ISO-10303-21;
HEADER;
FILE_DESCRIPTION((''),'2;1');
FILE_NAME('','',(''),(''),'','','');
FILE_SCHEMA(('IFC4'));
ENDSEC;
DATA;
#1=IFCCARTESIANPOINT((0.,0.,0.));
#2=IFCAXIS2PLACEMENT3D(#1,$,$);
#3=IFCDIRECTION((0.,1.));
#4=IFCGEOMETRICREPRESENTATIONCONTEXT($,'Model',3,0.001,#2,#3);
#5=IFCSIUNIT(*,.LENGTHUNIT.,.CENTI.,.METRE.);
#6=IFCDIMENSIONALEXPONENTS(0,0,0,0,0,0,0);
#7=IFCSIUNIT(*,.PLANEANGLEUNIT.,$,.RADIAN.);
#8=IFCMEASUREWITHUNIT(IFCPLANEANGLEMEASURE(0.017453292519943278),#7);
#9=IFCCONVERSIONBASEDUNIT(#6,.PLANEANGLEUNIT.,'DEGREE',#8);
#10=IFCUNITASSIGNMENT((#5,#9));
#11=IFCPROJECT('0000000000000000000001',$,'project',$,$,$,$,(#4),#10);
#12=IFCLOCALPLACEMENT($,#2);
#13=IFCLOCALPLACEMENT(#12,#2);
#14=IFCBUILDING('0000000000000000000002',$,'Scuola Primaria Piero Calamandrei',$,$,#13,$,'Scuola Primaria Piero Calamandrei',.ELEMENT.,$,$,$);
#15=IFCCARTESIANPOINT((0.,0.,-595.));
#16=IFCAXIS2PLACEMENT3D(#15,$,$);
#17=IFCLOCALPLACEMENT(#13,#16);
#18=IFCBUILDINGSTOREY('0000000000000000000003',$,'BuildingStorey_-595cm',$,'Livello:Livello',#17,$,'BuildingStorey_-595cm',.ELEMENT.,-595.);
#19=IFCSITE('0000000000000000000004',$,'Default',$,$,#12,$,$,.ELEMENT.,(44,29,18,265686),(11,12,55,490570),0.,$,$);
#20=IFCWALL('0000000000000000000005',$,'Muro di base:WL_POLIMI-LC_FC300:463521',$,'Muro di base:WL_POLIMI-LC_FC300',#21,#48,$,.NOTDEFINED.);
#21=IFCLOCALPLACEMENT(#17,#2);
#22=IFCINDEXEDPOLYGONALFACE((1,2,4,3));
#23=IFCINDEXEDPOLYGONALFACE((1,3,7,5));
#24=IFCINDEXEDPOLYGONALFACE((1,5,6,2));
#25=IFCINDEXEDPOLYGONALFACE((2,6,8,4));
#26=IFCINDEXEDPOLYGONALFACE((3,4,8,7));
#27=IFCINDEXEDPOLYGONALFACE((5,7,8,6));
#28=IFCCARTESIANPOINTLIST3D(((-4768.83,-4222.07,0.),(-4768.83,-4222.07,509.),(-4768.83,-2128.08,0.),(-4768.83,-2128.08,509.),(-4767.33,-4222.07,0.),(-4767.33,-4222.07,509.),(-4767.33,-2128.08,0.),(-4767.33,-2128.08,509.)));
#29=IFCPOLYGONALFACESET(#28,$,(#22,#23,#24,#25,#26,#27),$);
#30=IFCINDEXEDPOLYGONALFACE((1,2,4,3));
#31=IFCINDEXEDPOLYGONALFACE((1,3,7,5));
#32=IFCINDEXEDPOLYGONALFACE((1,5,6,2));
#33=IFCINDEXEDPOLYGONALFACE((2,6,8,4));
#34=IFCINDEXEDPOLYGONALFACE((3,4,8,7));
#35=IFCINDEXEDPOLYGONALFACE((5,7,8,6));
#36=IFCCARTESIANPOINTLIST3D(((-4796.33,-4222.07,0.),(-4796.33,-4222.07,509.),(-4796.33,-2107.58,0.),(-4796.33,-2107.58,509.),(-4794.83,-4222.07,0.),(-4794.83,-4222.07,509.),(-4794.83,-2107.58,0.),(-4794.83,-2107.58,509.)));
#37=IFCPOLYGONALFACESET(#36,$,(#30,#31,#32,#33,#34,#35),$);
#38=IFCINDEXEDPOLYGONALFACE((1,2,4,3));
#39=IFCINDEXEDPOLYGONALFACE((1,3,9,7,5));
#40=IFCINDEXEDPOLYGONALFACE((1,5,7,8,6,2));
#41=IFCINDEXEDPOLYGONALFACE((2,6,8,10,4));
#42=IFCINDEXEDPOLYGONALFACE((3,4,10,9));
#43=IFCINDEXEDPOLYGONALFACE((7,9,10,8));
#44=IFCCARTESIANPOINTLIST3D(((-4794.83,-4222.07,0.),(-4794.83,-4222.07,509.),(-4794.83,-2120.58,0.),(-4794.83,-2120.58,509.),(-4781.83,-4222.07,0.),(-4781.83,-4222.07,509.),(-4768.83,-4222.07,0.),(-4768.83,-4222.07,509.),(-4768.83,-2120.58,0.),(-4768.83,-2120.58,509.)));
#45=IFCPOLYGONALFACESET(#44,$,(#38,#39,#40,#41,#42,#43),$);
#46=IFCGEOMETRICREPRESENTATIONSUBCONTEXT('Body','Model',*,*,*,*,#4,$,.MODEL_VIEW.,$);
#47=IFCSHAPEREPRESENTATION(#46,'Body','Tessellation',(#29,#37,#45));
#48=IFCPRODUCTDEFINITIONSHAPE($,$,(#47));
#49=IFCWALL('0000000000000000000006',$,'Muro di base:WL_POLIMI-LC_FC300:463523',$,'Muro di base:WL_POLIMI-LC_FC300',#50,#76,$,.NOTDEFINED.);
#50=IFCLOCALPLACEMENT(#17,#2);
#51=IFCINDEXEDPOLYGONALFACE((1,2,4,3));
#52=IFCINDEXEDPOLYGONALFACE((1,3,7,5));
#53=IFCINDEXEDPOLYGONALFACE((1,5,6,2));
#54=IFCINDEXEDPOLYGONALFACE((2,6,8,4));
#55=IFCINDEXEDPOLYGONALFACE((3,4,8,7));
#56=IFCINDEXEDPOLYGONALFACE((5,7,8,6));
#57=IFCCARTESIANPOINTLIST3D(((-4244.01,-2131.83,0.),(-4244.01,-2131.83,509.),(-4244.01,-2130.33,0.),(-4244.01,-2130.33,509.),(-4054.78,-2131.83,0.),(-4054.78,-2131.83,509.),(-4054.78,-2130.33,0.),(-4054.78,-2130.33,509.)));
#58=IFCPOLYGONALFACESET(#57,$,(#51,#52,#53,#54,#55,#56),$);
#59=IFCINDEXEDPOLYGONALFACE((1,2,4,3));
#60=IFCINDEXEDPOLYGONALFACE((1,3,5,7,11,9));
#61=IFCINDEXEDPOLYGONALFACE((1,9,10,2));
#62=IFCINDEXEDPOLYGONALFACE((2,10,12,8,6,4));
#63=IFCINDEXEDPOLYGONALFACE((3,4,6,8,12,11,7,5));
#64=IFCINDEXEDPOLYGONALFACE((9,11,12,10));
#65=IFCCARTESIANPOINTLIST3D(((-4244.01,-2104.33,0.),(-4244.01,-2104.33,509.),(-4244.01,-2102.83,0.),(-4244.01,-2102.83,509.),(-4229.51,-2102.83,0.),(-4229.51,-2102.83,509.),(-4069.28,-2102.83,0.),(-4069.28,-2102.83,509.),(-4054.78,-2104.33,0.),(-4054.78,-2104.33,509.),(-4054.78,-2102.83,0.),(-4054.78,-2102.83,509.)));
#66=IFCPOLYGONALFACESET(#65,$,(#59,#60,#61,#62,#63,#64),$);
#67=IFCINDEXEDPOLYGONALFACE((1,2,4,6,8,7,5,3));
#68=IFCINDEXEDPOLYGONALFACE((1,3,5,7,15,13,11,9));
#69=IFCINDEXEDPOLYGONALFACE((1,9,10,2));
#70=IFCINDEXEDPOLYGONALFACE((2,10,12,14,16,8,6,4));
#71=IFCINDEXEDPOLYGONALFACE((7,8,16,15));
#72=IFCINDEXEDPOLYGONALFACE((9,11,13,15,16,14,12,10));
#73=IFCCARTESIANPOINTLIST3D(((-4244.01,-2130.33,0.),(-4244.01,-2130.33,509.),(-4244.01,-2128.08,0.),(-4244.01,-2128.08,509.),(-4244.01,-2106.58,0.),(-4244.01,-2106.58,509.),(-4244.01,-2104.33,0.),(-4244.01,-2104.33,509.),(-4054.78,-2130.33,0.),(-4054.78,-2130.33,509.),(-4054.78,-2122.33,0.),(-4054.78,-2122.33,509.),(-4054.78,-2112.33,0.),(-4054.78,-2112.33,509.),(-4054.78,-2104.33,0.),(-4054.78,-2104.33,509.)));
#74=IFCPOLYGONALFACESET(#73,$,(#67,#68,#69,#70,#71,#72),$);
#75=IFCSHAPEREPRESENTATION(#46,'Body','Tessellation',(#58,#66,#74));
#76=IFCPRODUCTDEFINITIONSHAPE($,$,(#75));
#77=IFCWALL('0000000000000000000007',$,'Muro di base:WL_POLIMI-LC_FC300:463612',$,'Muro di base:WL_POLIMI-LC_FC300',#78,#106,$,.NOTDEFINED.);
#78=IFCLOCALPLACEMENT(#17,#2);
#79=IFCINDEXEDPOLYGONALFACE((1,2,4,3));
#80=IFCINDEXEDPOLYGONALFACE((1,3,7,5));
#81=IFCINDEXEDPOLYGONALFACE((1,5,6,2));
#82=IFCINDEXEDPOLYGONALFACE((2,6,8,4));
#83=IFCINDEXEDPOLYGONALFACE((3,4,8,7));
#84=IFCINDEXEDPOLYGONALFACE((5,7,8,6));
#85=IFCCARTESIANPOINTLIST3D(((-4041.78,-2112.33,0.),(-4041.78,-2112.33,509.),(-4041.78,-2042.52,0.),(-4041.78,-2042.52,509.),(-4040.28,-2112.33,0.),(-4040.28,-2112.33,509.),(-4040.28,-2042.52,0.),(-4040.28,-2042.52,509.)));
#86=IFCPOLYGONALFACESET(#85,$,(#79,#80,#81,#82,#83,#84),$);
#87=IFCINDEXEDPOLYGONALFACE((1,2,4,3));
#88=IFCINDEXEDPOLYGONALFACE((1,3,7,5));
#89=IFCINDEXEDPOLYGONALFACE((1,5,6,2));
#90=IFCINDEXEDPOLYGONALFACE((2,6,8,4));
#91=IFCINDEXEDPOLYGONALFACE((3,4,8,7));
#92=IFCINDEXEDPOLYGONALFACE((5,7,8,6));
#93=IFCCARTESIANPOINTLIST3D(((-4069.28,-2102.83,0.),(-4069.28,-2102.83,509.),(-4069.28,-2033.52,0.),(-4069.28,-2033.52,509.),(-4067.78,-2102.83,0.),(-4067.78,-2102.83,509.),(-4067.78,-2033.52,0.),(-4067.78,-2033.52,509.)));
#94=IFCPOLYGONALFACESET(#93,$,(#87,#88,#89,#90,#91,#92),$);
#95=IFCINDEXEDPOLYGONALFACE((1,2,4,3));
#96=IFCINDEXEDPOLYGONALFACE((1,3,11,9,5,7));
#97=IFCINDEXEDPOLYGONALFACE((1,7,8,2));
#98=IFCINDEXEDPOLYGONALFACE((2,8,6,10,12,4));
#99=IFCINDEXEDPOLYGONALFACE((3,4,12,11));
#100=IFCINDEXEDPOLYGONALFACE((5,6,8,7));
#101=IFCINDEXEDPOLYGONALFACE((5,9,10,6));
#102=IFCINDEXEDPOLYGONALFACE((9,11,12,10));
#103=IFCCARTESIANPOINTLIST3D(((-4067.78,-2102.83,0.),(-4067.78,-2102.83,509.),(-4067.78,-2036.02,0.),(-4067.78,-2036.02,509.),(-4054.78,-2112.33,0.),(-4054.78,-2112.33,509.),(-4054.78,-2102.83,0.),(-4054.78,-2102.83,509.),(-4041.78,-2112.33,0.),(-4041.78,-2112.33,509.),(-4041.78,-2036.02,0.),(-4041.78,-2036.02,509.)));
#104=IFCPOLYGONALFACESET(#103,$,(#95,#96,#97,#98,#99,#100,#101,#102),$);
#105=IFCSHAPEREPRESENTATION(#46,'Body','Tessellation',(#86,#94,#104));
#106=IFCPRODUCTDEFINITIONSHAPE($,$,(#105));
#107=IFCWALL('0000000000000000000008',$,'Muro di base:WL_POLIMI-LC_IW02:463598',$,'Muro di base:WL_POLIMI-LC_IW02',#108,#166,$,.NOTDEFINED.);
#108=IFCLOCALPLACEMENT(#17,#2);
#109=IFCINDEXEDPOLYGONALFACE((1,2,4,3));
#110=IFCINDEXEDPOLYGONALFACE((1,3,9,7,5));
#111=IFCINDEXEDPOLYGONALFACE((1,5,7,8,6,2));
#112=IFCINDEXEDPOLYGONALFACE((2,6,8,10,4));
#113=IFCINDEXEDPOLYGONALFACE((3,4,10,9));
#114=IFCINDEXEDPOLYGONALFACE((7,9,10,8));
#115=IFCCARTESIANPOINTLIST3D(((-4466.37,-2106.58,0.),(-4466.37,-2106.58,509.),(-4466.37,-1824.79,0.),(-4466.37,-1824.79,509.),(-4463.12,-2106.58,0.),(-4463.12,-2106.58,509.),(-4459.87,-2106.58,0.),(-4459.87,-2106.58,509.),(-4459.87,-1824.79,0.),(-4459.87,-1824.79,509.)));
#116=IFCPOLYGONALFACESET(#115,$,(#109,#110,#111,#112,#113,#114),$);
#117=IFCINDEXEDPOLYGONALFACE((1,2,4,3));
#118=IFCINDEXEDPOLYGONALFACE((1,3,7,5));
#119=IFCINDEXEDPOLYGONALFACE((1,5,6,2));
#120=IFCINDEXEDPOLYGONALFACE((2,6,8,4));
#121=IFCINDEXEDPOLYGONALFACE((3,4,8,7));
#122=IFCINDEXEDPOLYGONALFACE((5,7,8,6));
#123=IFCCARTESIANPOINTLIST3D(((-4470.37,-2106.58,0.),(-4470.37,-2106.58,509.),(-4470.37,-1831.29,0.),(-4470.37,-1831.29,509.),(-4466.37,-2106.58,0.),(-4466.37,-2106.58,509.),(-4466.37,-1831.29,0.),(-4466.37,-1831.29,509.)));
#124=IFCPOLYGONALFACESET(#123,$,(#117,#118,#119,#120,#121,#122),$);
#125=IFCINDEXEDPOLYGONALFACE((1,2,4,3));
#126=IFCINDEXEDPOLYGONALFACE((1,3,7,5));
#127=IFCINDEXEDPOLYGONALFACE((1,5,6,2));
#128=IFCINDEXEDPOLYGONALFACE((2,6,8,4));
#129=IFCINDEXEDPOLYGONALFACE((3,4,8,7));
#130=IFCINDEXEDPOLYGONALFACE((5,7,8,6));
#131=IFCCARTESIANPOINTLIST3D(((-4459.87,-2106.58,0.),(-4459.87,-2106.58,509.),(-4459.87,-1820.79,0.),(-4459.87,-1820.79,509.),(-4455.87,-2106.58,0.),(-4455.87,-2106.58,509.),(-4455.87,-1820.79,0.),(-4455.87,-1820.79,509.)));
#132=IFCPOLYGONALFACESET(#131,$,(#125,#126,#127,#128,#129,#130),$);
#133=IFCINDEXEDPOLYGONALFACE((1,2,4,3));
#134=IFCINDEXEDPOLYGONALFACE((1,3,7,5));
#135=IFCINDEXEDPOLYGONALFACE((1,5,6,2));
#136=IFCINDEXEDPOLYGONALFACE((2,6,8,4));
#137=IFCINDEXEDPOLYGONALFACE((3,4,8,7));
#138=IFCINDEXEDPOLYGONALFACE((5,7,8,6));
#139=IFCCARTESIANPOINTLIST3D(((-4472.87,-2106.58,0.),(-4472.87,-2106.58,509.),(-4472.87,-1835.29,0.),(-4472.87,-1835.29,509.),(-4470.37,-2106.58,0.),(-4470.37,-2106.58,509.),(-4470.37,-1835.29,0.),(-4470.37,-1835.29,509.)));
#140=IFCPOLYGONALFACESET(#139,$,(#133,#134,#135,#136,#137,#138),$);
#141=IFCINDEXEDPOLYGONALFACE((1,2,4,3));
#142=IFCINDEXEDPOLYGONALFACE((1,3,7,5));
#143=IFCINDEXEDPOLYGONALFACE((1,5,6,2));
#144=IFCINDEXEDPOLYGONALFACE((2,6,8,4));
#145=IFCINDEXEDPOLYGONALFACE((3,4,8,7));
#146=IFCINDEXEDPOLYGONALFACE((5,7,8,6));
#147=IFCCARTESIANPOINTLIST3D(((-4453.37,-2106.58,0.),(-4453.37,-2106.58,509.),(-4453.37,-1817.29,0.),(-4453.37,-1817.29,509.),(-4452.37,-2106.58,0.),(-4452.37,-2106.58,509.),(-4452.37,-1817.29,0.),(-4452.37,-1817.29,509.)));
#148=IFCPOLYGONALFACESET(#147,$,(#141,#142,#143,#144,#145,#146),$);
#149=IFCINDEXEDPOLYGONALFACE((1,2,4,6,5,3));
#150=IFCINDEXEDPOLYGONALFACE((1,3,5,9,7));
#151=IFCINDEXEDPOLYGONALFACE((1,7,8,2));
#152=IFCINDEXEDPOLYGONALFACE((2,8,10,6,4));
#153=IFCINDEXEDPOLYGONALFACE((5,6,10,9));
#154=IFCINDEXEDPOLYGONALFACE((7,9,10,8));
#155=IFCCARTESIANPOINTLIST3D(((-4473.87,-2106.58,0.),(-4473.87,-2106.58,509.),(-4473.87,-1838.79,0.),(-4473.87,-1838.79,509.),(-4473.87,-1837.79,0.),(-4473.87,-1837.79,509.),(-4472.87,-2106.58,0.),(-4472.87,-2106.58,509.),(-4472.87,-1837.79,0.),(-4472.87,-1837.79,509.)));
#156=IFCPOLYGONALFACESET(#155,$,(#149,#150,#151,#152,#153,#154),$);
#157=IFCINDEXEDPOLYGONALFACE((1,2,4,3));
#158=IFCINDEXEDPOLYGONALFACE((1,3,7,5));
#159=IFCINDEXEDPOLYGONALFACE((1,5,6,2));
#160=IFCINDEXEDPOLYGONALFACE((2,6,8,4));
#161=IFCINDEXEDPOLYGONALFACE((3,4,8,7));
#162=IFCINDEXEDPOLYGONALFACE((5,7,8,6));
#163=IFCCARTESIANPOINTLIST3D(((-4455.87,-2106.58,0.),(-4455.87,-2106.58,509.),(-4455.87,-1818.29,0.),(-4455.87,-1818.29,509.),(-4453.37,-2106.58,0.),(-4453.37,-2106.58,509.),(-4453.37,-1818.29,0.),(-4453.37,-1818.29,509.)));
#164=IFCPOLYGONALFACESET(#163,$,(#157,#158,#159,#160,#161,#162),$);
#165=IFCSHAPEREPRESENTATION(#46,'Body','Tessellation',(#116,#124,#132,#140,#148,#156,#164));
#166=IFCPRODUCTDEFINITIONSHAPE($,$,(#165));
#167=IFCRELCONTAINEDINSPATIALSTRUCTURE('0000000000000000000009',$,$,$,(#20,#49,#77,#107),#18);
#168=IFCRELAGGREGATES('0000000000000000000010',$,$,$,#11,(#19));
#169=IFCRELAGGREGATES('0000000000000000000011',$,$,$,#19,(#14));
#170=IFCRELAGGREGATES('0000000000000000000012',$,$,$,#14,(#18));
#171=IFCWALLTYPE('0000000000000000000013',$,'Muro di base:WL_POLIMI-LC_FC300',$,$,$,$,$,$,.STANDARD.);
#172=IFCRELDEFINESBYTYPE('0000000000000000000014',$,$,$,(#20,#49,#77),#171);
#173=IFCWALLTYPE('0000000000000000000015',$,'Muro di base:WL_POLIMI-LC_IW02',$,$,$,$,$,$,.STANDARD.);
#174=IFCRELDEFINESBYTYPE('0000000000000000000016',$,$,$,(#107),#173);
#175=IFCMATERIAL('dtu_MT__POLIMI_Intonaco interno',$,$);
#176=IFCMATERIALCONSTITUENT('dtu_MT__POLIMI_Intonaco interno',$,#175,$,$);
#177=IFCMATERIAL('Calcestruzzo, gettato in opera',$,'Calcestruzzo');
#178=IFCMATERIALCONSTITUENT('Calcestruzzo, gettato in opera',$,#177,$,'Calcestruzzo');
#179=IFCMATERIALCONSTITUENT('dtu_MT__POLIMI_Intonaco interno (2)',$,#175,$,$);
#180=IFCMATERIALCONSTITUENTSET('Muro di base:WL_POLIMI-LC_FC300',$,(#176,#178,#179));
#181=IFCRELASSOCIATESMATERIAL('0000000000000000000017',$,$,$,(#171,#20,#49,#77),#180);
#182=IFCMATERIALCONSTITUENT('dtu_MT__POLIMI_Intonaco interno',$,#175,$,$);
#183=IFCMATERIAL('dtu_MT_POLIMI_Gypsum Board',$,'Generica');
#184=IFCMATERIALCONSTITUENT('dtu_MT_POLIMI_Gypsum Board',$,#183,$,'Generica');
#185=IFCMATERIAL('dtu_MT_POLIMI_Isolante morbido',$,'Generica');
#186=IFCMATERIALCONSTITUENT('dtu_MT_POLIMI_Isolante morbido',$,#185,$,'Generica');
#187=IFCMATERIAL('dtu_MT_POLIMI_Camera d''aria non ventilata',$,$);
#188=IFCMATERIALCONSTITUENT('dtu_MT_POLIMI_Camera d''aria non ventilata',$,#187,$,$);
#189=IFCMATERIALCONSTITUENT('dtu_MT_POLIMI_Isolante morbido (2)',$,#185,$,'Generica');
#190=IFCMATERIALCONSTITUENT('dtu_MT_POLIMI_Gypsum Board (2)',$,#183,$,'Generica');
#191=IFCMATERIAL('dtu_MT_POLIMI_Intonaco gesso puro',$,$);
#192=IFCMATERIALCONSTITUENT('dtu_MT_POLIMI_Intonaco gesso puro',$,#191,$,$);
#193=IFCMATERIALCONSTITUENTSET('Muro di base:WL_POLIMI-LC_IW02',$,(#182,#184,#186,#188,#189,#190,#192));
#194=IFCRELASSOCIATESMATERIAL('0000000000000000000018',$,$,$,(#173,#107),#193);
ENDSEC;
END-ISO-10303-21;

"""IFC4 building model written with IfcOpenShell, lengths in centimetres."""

from ifc_helpers import new_model, entity, si_unit, converted_unit, direction, frame, origin, place, context, subcontext, project, spatial, indexed_curve, outline, extrude, material, constituent, constituent_set, type_object, element, save


model = new_model("IFC4")

# Units and contexts
model_context = context("Model", 3, precision=0.001, world=origin(), true_north=direction((0.0, 1.0)))
body_context = subcontext(model_context, "Body", "Model", "MODEL_VIEW")
ifc_project = project(units=[si_unit("LENGTHUNIT", "METRE", prefix="CENTI"), converted_unit("PLANEANGLEUNIT", "DEGREE", entity("IfcPlaneAngleMeasure", 0.017453292519943278), si_unit("PLANEANGLEUNIT", "RADIAN"), dimensions=[0, 0, 0, 0, 0, 0, 0])], contexts=[model_context])

# Site, building, storey
site_placement = place(None, origin())
site = spatial("IfcSite", under=ifc_project, at=site_placement, Name="Default", CompositionType="ELEMENT", RefLatitude=(44, 29, 18, 265686), RefLongitude=(11, 12, 55, 490570), RefElevation=0.0)
building_placement = place(site_placement, origin())
building = spatial("IfcBuilding", under=site, at=building_placement, Name="Scuola Primaria Piero Calamandrei", LongName="Scuola Primaria Piero Calamandrei", CompositionType="ELEMENT")
storey_placement = place(building_placement, frame((0.0, 0.0, -595.0)))
storey = spatial("IfcBuildingStorey", under=building, at=storey_placement, Name="BuildingStorey_-595cm", ObjectType="Livello:Livello", LongName="BuildingStorey_-595cm", CompositionType="ELEMENT", Elevation=-595.0)

# Walls
ifc_material_1 = material(Name="dtu_MT__POLIMI_Intonaco interno")
ifc_constituent_1 = constituent(ifc_material_1, Name="dtu_MT__POLIMI_Intonaco interno")
ifc_material_2 = material(Name="Calcestruzzo, gettato in opera", Category="Calcestruzzo")
ifc_constituent_2 = constituent(ifc_material_2, Name="Calcestruzzo, gettato in opera", Category="Calcestruzzo")
ifc_constituent_3 = constituent(ifc_material_1, Name="dtu_MT__POLIMI_Intonaco interno (2)")
ifc_constituent_set_1 = constituent_set(constituents=[ifc_constituent_1, ifc_constituent_2, ifc_constituent_3], Name="Muro di base:WL_POLIMI-LC_FC300")
wall_type_1 = type_object("IfcWallType", Name="Muro di base:WL_POLIMI-LC_FC300", PredefinedType="STANDARD", material=ifc_constituent_set_1)
wall_1_placement = place(storey_placement, frame((-4781.83, -4222.07, 0.0), z_axis=(0.0, 0.0, 1.0), x_axis=(0.0, 1.0, 0.0)))
element("IfcWall", 1, at=wall_1_placement, inside=storey, type_object=wall_type_1, material=ifc_constituent_set_1, Name="Muro di base:WL_POLIMI-LC_FC300:463521", ObjectType="Muro di base:WL_POLIMI-LC_FC300", PredefinedType="NOTDEFINED", context=body_context, shape_type="SweptSolid", body=[
    extrude(outline(indexed_curve([(-0.75, -1047.0), (0.75, -1047.0), (0.75, 1047.0), (-0.75, 1047.0), (-0.75, -1047.0)], self_intersect=False)), frame((1047.0, -13.75, 0.0), z_axis=(0.0, 0.0, 1.0), x_axis=(0.0, 1.0, 0.0)), (0.0, 0.0, 1.0), 509.0),
    extrude(outline(indexed_curve([(-0.75, -1057.25), (0.75, -1057.25), (0.75, 1057.25), (-0.75, 1057.25), (-0.75, -1057.25)], self_intersect=False)), frame((1057.25, 13.75, 0.0), z_axis=(0.0, 0.0, 1.0), x_axis=(0.0, -1.0, 0.0)), (0.0, 0.0, 1.0), 509.0),
    extrude(outline(indexed_curve([(-840.6, -13.0), (1260.9, -13.0), (1260.9, 13.0), (-840.6, 13.0), (-840.6, 0.0), (-840.6, -13.0)], self_intersect=False)), frame((840.6, 0.0, 0.0)), (0.0, 0.0, 1.0), 509.0),
])
wall_2_placement = place(storey_placement, frame((-4244.01, -2117.33, 0.0)))
element("IfcWall", 2, at=wall_2_placement, inside=storey, type_object=wall_type_1, material=ifc_constituent_set_1, Name="Muro di base:WL_POLIMI-LC_FC300:463523", ObjectType="Muro di base:WL_POLIMI-LC_FC300", PredefinedType="NOTDEFINED", context=body_context, shape_type="SweptSolid", body=[
    extrude(outline(indexed_curve([(-0.75, -94.62), (0.75, -94.62), (0.75, 94.62), (-0.75, 94.62), (-0.75, -94.62)], self_intersect=False)), frame((94.62, -13.75, 0.0), z_axis=(0.0, 0.0, 1.0), x_axis=(0.0, 1.0, 0.0)), (0.0, 0.0, 1.0), 509.0),
    extrude(outline(indexed_curve([(-80.12, -0.5), (80.12, -0.5), (94.62, -0.5), (94.62, 1.0), (-94.62, 1.0), (-94.62, -0.5), (-80.12, -0.5)], self_intersect=False)), frame((94.62, 14.0, 0.0), z_axis=(0.0, 0.0, 1.0), x_axis=(-1.0, 0.0, 0.0)), (0.0, 0.0, 1.0), 509.0),
    extrude(outline(indexed_curve([(10.75, -94.62), (13.0, -94.62), (13.0, 94.62), (5.0, 94.62), (-5.0, 94.62), (-13.0, 94.62), (-13.0, -94.62), (-10.75, -94.62), (10.75, -94.62)], self_intersect=False)), frame((94.62, 0.0, 0.0), z_axis=(0.0, 0.0, 1.0), x_axis=(0.0, -1.0, 0.0)), (0.0, 0.0, 1.0), 509.0),
])

# Wall
wall_3_placement = place(storey_placement, frame((-4054.78, -2112.33, 0.0), z_axis=(0.0, 0.0, 1.0), x_axis=(0.0, 1.0, 0.0)))
element("IfcWall", 3, at=wall_3_placement, inside=storey, type_object=wall_type_1, material=ifc_constituent_set_1, Name="Muro di base:WL_POLIMI-LC_FC300:463612", ObjectType="Muro di base:WL_POLIMI-LC_FC300", PredefinedType="NOTDEFINED", context=body_context, shape_type="SweptSolid", body=[
    extrude(outline(indexed_curve([(-0.75, -34.9), (0.75, -34.9), (0.75, 34.9), (-0.75, 34.9), (-0.75, -34.9)], self_intersect=False)), frame((34.9, -13.75, 0.0), z_axis=(0.0, 0.0, 1.0), x_axis=(0.0, 1.0, 0.0)), (0.0, 0.0, 1.0), 509.0),
    extrude(outline(indexed_curve([(-0.75, -34.65), (0.75, -34.65), (0.75, 34.65), (-0.75, 34.65), (-0.75, -34.65)], self_intersect=False)), frame((44.15, 13.75, 0.0), z_axis=(0.0, 0.0, 1.0), x_axis=(0.0, -1.0, 0.0)), (0.0, 0.0, 1.0), 509.0),
    extrude(outline(indexed_curve([(0.0, -28.6), (13.0, -28.6), (13.0, 47.7), (-13.0, 47.7), (-13.0, -19.1), (0.0, -19.1), (0.0, -28.6)], self_intersect=False)), frame((28.6, 0.0, 0.0), z_axis=(0.0, 0.0, 1.0), x_axis=(0.0, -1.0, 0.0)), (0.0, 0.0, 1.0), 509.0),
])

# Shared definitions
ifc_constituent_4 = constituent(ifc_material_1, Name="dtu_MT__POLIMI_Intonaco interno")
ifc_material_3 = material(Name="dtu_MT_POLIMI_Gypsum Board", Category="Generica")
ifc_constituent_5 = constituent(ifc_material_3, Name="dtu_MT_POLIMI_Gypsum Board", Category="Generica")
ifc_material_4 = material(Name="dtu_MT_POLIMI_Isolante morbido", Category="Generica")
ifc_constituent_6 = constituent(ifc_material_4, Name="dtu_MT_POLIMI_Isolante morbido", Category="Generica")
ifc_material_5 = material(Name="dtu_MT_POLIMI_Camera d'aria non ventilata")
ifc_constituent_7 = constituent(ifc_material_5, Name="dtu_MT_POLIMI_Camera d'aria non ventilata")
ifc_constituent_8 = constituent(ifc_material_4, Name="dtu_MT_POLIMI_Isolante morbido (2)", Category="Generica")
ifc_constituent_9 = constituent(ifc_material_3, Name="dtu_MT_POLIMI_Gypsum Board (2)", Category="Generica")
ifc_material_6 = material(Name="dtu_MT_POLIMI_Intonaco gesso puro")
ifc_constituent_10 = constituent(ifc_material_6, Name="dtu_MT_POLIMI_Intonaco gesso puro")
ifc_constituent_set_2 = constituent_set(constituents=[ifc_constituent_4, ifc_constituent_5, ifc_constituent_6, ifc_constituent_7, ifc_constituent_8, ifc_constituent_9, ifc_constituent_10], Name="Muro di base:WL_POLIMI-LC_IW02")
wall_type_2 = type_object("IfcWallType", Name="Muro di base:WL_POLIMI-LC_IW02", PredefinedType="STANDARD", material=ifc_constituent_set_2)

# Wall
wall_4_placement = place(storey_placement, frame((-4463.12, -2106.58, 0.0), z_axis=(0.0, 0.0, 1.0), x_axis=(0.0, 1.0, 0.0)))
element("IfcWall", 4, at=wall_4_placement, inside=storey, type_object=wall_type_2, material=ifc_constituent_set_2, Name="Muro di base:WL_POLIMI-LC_IW02:463598", ObjectType="Muro di base:WL_POLIMI-LC_IW02", PredefinedType="NOTDEFINED", context=body_context, shape_type="SweptSolid", body=[
    extrude(outline(indexed_curve([(-112.72, -3.25), (169.07, -3.25), (169.07, 3.25), (-112.72, 3.25), (-112.72, 0.0), (-112.72, -3.25)], self_intersect=False)), frame((112.72, 0.0, 0.0)), (0.0, 0.0, 1.0), 509.0),
    extrude(outline(indexed_curve([(-137.65, -2.0), (137.65, -2.0), (137.65, 2.0), (-137.65, 2.0), (-137.65, -2.0)], self_intersect=False)), frame((137.65, 5.25, 0.0)), (0.0, 0.0, 1.0), 509.0),
    extrude(outline(indexed_curve([(-142.9, -2.0), (142.9, -2.0), (142.9, 2.0), (-142.9, 2.0), (-142.9, -2.0)], self_intersect=False)), frame((142.9, -5.25, 0.0)), (0.0, 0.0, 1.0), 509.0),
    extrude(outline(indexed_curve([(-135.65, -1.25), (135.65, -1.25), (135.65, 1.25), (-135.65, 1.25), (-135.65, -1.25)], self_intersect=False)), frame((135.65, 8.5, 0.0)), (0.0, 0.0, 1.0), 509.0),
    extrude(outline(indexed_curve([(-0.5, -144.65), (0.5, -144.65), (0.5, 144.65), (-0.5, 144.65), (-0.5, -144.65)], self_intersect=False)), frame((144.65, -10.25, 0.0), z_axis=(0.0, 0.0, 1.0), x_axis=(0.0, 1.0, 0.0)), (0.0, 0.0, 1.0), 509.0),
    extrude(outline(indexed_curve([(-106.72, -0.4), (161.07, -0.4), (161.07, 0.6), (-107.72, 0.6), (-107.72, -0.4), (-106.72, -0.4)], self_intersect=False)), frame((161.07, 10.35, 0.0), z_axis=(0.0, 0.0, 1.0), x_axis=(-1.0, 0.0, 0.0)), (0.0, 0.0, 1.0), 509.0),
    extrude(outline(indexed_curve([(-144.15, -1.25), (144.15, -1.25), (144.15, 1.25), (-144.15, 1.25), (-144.15, -1.25)], self_intersect=False)), frame((144.15, -8.5, 0.0)), (0.0, 0.0, 1.0), 509.0),
])

save(model, "model.ifc")
